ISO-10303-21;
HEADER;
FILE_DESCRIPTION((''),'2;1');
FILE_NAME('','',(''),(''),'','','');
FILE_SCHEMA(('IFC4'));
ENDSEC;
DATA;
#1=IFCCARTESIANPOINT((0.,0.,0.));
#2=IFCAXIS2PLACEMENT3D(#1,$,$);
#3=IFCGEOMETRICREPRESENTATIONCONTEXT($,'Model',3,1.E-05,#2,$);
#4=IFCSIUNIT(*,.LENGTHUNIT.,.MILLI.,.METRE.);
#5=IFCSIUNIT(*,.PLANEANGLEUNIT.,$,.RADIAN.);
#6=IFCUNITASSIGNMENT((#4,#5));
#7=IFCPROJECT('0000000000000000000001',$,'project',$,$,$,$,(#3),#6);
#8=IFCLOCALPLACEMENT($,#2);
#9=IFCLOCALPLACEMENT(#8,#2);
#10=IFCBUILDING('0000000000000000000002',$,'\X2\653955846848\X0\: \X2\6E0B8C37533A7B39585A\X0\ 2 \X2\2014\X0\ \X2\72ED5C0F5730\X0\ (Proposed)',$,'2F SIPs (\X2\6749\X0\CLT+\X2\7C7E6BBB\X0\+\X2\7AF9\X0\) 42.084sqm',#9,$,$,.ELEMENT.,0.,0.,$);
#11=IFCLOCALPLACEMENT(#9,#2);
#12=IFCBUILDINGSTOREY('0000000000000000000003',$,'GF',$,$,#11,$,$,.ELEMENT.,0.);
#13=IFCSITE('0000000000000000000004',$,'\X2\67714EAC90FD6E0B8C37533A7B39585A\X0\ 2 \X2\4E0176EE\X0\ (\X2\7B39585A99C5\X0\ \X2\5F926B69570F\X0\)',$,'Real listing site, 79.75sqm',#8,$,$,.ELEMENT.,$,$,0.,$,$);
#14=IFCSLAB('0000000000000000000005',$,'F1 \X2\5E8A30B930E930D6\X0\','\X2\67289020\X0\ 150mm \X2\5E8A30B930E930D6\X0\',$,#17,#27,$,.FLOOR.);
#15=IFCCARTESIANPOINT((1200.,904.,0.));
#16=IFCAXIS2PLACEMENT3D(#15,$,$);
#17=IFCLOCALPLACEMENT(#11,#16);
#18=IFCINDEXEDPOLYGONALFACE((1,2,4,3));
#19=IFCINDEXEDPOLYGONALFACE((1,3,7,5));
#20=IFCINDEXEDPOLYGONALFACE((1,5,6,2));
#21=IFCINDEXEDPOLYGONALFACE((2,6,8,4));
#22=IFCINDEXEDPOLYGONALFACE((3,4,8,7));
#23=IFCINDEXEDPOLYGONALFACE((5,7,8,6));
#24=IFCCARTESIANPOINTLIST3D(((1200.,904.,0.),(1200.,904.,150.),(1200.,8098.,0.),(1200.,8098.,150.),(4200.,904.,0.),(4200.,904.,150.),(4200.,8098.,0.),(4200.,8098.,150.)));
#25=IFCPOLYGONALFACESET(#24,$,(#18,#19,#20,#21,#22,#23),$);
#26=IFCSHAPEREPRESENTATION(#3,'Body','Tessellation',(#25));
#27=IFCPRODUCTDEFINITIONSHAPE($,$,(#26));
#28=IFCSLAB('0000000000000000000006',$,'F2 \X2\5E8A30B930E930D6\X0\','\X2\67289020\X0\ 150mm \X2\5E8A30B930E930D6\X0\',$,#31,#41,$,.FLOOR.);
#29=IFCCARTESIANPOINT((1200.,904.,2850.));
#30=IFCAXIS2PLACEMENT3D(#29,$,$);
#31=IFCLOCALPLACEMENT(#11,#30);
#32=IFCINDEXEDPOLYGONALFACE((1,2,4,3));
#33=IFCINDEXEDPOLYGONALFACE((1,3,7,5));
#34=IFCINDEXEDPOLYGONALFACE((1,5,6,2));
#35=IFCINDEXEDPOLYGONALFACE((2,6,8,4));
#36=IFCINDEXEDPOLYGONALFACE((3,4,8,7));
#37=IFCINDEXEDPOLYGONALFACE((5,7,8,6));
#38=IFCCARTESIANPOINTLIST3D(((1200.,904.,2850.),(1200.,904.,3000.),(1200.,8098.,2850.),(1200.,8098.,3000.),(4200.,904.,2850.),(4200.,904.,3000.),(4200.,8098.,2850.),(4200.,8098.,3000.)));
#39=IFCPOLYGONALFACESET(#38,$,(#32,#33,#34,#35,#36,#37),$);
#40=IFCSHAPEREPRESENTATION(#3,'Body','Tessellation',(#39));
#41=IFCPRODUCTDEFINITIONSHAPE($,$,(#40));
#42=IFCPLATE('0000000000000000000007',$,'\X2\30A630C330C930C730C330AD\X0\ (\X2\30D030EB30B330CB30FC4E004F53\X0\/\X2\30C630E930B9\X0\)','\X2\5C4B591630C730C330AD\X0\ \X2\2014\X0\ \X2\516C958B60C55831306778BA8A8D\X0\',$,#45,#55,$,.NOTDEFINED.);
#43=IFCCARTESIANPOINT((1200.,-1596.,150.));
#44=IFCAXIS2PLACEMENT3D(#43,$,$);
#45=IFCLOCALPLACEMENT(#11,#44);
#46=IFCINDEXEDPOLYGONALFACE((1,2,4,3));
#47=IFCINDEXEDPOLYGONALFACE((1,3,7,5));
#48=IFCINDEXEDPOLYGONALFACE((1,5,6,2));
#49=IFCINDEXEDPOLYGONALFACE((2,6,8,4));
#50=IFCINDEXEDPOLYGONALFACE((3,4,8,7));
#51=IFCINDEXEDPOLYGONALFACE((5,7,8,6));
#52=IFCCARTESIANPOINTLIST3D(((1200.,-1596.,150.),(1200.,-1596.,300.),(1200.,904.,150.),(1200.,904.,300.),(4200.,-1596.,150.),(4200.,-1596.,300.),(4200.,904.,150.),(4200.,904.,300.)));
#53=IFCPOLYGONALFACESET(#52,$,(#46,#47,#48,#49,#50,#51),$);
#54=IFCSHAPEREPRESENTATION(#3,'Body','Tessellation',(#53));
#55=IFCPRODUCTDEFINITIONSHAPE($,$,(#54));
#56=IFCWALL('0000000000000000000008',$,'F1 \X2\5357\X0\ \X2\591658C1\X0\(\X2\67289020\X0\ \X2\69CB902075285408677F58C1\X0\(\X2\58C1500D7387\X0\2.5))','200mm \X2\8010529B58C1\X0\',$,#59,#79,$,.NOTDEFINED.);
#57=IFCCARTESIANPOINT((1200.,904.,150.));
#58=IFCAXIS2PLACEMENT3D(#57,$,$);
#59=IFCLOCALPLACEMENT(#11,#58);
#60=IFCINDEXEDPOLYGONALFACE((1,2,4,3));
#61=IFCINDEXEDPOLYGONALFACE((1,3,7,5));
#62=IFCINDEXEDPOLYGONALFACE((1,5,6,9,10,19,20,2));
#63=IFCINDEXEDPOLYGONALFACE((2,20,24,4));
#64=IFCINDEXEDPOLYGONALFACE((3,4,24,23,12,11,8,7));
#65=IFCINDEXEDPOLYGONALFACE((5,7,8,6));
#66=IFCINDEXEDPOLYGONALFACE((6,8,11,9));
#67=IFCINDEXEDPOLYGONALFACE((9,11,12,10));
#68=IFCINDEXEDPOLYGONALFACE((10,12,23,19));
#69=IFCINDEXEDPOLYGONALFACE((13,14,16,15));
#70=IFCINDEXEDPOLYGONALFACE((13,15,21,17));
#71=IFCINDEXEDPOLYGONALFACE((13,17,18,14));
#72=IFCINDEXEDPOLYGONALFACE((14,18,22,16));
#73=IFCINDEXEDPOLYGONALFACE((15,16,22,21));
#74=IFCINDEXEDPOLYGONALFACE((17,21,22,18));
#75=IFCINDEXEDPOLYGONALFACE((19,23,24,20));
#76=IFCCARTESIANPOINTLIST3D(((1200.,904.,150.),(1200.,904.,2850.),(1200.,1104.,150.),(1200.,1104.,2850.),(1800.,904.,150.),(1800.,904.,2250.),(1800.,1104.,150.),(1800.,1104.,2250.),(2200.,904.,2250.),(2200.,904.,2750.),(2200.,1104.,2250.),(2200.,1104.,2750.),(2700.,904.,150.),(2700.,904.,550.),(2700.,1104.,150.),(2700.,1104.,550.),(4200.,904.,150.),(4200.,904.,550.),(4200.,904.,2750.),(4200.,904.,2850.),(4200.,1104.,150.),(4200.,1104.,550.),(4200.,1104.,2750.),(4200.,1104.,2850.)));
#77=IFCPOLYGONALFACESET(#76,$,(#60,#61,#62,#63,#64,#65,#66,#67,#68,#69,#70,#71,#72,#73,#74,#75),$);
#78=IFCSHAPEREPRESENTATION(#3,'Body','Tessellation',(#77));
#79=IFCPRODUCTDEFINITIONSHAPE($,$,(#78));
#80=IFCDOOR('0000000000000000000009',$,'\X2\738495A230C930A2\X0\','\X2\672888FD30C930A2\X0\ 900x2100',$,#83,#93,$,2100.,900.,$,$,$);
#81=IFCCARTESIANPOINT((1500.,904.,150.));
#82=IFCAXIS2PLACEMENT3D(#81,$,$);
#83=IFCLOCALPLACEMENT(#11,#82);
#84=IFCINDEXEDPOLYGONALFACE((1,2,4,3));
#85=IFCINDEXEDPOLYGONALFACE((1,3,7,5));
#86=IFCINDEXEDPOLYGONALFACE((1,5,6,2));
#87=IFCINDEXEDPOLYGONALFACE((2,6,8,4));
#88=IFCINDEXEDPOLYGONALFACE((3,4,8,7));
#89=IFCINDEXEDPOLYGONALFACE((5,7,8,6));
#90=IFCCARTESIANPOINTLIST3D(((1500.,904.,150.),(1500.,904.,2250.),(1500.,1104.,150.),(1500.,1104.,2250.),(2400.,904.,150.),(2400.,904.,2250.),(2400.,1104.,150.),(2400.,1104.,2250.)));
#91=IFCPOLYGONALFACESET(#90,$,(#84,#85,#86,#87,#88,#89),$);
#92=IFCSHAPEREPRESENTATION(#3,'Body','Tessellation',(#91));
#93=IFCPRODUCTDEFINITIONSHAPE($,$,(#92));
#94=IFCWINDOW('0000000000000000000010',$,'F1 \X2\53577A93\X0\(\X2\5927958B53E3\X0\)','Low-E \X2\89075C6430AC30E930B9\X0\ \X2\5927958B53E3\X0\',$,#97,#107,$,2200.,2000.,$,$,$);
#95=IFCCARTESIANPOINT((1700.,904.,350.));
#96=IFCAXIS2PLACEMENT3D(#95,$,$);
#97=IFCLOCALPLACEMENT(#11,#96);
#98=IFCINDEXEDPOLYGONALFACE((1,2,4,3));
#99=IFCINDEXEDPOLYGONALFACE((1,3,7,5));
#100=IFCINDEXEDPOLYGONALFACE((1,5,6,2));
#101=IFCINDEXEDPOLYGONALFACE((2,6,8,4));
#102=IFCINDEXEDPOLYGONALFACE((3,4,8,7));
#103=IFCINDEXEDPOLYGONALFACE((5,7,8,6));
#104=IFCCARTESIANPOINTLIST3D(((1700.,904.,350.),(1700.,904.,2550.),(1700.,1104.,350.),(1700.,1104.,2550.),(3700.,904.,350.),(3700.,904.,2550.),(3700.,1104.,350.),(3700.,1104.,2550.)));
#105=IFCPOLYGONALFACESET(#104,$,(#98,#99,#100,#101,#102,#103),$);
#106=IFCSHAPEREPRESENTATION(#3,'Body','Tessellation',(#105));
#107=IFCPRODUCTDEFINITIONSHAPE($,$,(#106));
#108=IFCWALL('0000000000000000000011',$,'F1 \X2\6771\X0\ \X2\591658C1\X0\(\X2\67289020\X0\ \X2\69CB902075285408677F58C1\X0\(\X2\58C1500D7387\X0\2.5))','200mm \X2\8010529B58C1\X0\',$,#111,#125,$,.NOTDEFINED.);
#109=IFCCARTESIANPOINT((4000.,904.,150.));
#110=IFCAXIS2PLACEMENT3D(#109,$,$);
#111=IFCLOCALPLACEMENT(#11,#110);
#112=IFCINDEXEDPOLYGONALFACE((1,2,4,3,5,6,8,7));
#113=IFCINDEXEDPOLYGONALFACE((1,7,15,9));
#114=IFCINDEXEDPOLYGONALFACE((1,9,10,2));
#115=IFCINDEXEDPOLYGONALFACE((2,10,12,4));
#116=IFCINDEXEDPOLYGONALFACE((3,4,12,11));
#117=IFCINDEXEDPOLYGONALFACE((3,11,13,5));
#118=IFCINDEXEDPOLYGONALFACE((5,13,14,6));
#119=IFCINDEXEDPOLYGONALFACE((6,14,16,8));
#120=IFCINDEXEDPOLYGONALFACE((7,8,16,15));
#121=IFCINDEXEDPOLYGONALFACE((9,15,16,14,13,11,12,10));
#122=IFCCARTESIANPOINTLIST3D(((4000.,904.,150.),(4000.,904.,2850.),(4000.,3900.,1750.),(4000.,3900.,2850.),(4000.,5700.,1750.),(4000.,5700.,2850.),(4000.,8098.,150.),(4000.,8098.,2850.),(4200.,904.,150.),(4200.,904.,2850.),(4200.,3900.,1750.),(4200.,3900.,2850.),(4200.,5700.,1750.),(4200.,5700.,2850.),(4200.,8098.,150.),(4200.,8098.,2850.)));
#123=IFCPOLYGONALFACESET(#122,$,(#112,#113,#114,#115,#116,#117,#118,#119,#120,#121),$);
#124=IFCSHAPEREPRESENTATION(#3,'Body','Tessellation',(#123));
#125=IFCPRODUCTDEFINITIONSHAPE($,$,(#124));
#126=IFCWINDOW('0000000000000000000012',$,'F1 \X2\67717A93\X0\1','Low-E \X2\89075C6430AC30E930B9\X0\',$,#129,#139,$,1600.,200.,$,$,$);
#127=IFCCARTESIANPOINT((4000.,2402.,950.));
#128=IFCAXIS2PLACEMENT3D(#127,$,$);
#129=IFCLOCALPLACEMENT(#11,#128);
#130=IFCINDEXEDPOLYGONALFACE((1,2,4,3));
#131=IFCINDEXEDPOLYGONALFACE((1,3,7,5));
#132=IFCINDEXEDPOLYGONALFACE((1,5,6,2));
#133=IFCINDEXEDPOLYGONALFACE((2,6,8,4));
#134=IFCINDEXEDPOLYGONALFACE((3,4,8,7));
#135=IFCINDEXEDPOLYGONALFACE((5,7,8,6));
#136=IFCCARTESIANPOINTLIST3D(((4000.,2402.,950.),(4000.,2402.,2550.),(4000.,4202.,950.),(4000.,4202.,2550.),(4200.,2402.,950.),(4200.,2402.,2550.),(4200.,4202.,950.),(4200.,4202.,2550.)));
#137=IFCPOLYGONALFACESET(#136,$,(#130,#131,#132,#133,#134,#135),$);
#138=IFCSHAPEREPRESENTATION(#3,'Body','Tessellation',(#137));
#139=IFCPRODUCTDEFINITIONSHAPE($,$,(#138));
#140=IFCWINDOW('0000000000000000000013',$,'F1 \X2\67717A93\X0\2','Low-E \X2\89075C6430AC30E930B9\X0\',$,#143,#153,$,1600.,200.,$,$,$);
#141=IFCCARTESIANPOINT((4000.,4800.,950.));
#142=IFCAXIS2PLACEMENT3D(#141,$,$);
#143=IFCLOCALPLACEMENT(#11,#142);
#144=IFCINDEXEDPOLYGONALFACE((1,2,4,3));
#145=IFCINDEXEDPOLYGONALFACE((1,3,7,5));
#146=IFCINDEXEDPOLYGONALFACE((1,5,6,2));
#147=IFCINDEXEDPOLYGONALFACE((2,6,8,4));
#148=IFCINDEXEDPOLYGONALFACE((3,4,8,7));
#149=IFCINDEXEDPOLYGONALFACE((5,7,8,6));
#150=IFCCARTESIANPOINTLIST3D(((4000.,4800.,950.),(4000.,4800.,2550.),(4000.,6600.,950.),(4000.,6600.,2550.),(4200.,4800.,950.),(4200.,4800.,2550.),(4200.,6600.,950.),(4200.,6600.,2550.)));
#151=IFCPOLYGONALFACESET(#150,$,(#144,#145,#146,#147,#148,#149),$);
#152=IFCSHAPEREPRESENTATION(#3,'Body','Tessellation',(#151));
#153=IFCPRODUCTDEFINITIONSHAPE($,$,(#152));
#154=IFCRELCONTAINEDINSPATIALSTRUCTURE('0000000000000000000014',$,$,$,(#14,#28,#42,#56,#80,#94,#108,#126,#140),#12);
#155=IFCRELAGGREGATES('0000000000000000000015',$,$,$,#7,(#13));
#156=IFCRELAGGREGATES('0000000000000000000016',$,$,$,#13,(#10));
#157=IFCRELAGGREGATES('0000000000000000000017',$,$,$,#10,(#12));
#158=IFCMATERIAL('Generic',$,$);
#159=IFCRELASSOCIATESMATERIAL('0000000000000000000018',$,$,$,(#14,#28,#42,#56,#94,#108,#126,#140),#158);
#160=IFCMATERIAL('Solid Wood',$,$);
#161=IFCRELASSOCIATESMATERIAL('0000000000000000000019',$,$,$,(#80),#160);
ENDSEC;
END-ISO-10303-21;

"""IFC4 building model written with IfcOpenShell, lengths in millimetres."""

from ifc_helpers import new_model, si_unit, frame, frame_2d, origin, place, context, project, spatial, rectangle, extrude, material, element, fill, save


model = new_model("IFC4")

# Units and contexts
model_context = context("Model", 3, precision=1e-05, world=origin())
ifc_project = project(units=[si_unit("LENGTHUNIT", "METRE", prefix="MILLI"), si_unit("PLANEANGLEUNIT", "RADIAN")], contexts=[model_context])

# Site, building, storey
site_placement = place(None, origin())
site = spatial("IfcSite", under=ifc_project, at=site_placement, Name="東京都渋谷区笹塚 2 丁目 (笹塚駅 徒歩圏)", ObjectType="Real listing site, 79.75sqm", CompositionType="ELEMENT", RefElevation=0.0)
building_placement = place(site_placement, origin())
building = spatial("IfcBuilding", under=site, at=building_placement, Name="改善案: 渋谷区笹塚 2 — 狭小地 (Proposed)", ObjectType="2F SIPs (杉CLT+籾殻+竹) 42.084sqm", CompositionType="ELEMENT", ElevationOfRefHeight=0.0, ElevationOfTerrain=0.0)
storey_placement = place(building_placement, origin())
storey = spatial("IfcBuildingStorey", under=building, at=storey_placement, Name="GF", CompositionType="ELEMENT", Elevation=0.0)

# Slabs
ifc_material_1 = material(Name="Generic")
slab_1_placement = place(storey_placement, frame((1200.0, 904.0, 0.0)))
element("IfcSlab", 1, at=slab_1_placement, inside=storey, material=ifc_material_1, Name="F1 床スラブ", Description="木造 150mm 床スラブ", PredefinedType="FLOOR", context=model_context, shape_type="SweptSolid", body=[
    extrude(rectangle(XDim=3000.0, YDim=7194.0, at=frame_2d((1500.0, 3597.0))), frame((1200.0, 904.0, 0.0)), (0.0, 0.0, 1.0), 150.0),
])
slab_2_placement = place(storey_placement, frame((1200.0, 904.0, 2850.0)))
element("IfcSlab", 2, at=slab_2_placement, inside=storey, material=ifc_material_1, Name="F2 床スラブ", Description="木造 150mm 床スラブ", PredefinedType="FLOOR", context=model_context, shape_type="SweptSolid", body=[
    extrude(rectangle(XDim=3000.0, YDim=7194.0, at=frame_2d((1500.0, 3597.0))), frame((1200.0, 904.0, 2850.0)), (0.0, 0.0, 1.0), 150.0),
])

# Plate
plate_placement = place(storey_placement, frame((1200.0, -1596.0, 150.0)))
element("IfcPlate", 3, at=plate_placement, inside=storey, material=ifc_material_1, Name="ウッドデッキ (バルコニー一体/テラス)", Description="屋外デッキ — 公開情報で確認", PredefinedType="NOTDEFINED", context=model_context, shape_type="SweptSolid", body=[
    extrude(rectangle(XDim=3000.0, YDim=2500.0, at=frame_2d((1500.0, 1250.0))), frame((1200.0, -1596.0, 150.0)), (0.0, 0.0, 1.0), 150.0),
])

# Wall, openings, door, window
wall_1_placement = place(storey_placement, frame((1200.0, 904.0, 150.0)))
wall_1 = element("IfcWall", 4, at=wall_1_placement, inside=storey, material=ifc_material_1, Name="F1 南 外壁(木造 構造用合板壁(壁倍率2.5))", Description="200mm 耐力壁", PredefinedType="NOTDEFINED", context=model_context, shape_type="SweptSolid", body=[
    extrude(rectangle(XDim=3000.0, YDim=200.0, at=frame_2d((1500.0, 100.0))), frame((1200.0, 904.0, 150.0)), (0.0, 0.0, 1.0), 2700.0),
])
opening_1_placement = place(storey_placement, frame((1500.0, 904.0, 150.0)))
opening_1 = element("IfcOpeningElement", 5, at=opening_1_placement, cuts=wall_1, PredefinedType="NOTDEFINED", context=model_context, shape_type="SweptSolid", body=[
    extrude(rectangle(XDim=900.0, YDim=200.0, at=frame_2d((450.0, 100.0))), frame((1500.0, 904.0, 150.0)), (0.0, 0.0, 1.0), 2100.0),
])
opening_2_placement = place(storey_placement, frame((1700.0, 904.0, 350.0)))
opening_2 = element("IfcOpeningElement", 6, at=opening_2_placement, cuts=wall_1, PredefinedType="NOTDEFINED", context=model_context, shape_type="SweptSolid", body=[
    extrude(rectangle(XDim=2000.0, YDim=200.0, at=frame_2d((1000.0, 100.0))), frame((1700.0, 904.0, 350.0)), (0.0, 0.0, 1.0), 2200.0),
])
ifc_material_2 = material(Name="Solid Wood")
door_placement = place(storey_placement, frame((1500.0, 904.0, 150.0)))
door = element("IfcDoor", 7, at=door_placement, inside=storey, material=ifc_material_2, Name="玄関ドア", Description="木製ドア 900x2100", OverallHeight=2100.0, OverallWidth=900.0, context=model_context, shape_type="SweptSolid", body=[
    extrude(rectangle(XDim=900.0, YDim=200.0, at=frame_2d((450.0, 100.0))), frame((1500.0, 904.0, 150.0)), (0.0, 0.0, 1.0), 2100.0),
])
fill(opening_1, door)
window_1_placement = place(storey_placement, frame((1700.0, 904.0, 350.0)))
window_1 = element("IfcWindow", 8, at=window_1_placement, inside=storey, material=ifc_material_1, Name="F1 南窓(大開口)", Description="Low-E 複層ガラス 大開口", OverallHeight=2200.0, OverallWidth=2000.0, context=model_context, shape_type="SweptSolid", body=[
    extrude(rectangle(XDim=2000.0, YDim=200.0, at=frame_2d((1000.0, 100.0))), frame((1700.0, 904.0, 350.0)), (0.0, 0.0, 1.0), 2200.0),
])
fill(opening_2, window_1)

# Wall, openings, windows
wall_2_placement = place(storey_placement, frame((4000.0, 904.0, 150.0)))
wall_2 = element("IfcWall", 9, at=wall_2_placement, inside=storey, material=ifc_material_1, Name="F1 東 外壁(木造 構造用合板壁(壁倍率2.5))", Description="200mm 耐力壁", PredefinedType="NOTDEFINED", context=model_context, shape_type="SweptSolid", body=[
    extrude(rectangle(XDim=200.0, YDim=7194.0, at=frame_2d((100.0, 3597.0))), frame((4000.0, 904.0, 150.0)), (0.0, 0.0, 1.0), 2700.0),
])
opening_3_placement = place(storey_placement, frame((4000.0, 2402.0, 950.0)))
opening_3 = element("IfcOpeningElement", 10, at=opening_3_placement, cuts=wall_2, PredefinedType="NOTDEFINED", context=model_context, shape_type="SweptSolid", body=[
    extrude(rectangle(XDim=200.0, YDim=1800.0, at=frame_2d((100.0, 900.0))), frame((4000.0, 2402.0, 950.0)), (0.0, 0.0, 1.0), 1600.0),
])
opening_4_placement = place(storey_placement, frame((4000.0, 4800.0, 950.0)))
opening_4 = element("IfcOpeningElement", 11, at=opening_4_placement, cuts=wall_2, PredefinedType="NOTDEFINED", context=model_context, shape_type="SweptSolid", body=[
    extrude(rectangle(XDim=200.0, YDim=1800.0, at=frame_2d((100.0, 900.0))), frame((4000.0, 4800.0, 950.0)), (0.0, 0.0, 1.0), 1600.0),
])
window_2_placement = place(storey_placement, frame((4000.0, 2402.0, 950.0)))
window_2 = element("IfcWindow", 12, at=window_2_placement, inside=storey, material=ifc_material_1, Name="F1 東窓1", Description="Low-E 複層ガラス", OverallHeight=1600.0, OverallWidth=200.0, context=model_context, shape_type="SweptSolid", body=[
    extrude(rectangle(XDim=200.0, YDim=1800.0, at=frame_2d((100.0, 900.0))), frame((4000.0, 2402.0, 950.0)), (0.0, 0.0, 1.0), 1600.0),
])
fill(opening_3, window_2)
window_3_placement = place(storey_placement, frame((4000.0, 4800.0, 950.0)))
window_3 = element("IfcWindow", 13, at=window_3_placement, inside=storey, material=ifc_material_1, Name="F1 東窓2", Description="Low-E 複層ガラス", OverallHeight=1600.0, OverallWidth=200.0, context=model_context, shape_type="SweptSolid", body=[
    extrude(rectangle(XDim=200.0, YDim=1800.0, at=frame_2d((100.0, 900.0))), frame((4000.0, 4800.0, 950.0)), (0.0, 0.0, 1.0), 1600.0),
])
fill(opening_4, window_3)

save(model, "model.ifc")
